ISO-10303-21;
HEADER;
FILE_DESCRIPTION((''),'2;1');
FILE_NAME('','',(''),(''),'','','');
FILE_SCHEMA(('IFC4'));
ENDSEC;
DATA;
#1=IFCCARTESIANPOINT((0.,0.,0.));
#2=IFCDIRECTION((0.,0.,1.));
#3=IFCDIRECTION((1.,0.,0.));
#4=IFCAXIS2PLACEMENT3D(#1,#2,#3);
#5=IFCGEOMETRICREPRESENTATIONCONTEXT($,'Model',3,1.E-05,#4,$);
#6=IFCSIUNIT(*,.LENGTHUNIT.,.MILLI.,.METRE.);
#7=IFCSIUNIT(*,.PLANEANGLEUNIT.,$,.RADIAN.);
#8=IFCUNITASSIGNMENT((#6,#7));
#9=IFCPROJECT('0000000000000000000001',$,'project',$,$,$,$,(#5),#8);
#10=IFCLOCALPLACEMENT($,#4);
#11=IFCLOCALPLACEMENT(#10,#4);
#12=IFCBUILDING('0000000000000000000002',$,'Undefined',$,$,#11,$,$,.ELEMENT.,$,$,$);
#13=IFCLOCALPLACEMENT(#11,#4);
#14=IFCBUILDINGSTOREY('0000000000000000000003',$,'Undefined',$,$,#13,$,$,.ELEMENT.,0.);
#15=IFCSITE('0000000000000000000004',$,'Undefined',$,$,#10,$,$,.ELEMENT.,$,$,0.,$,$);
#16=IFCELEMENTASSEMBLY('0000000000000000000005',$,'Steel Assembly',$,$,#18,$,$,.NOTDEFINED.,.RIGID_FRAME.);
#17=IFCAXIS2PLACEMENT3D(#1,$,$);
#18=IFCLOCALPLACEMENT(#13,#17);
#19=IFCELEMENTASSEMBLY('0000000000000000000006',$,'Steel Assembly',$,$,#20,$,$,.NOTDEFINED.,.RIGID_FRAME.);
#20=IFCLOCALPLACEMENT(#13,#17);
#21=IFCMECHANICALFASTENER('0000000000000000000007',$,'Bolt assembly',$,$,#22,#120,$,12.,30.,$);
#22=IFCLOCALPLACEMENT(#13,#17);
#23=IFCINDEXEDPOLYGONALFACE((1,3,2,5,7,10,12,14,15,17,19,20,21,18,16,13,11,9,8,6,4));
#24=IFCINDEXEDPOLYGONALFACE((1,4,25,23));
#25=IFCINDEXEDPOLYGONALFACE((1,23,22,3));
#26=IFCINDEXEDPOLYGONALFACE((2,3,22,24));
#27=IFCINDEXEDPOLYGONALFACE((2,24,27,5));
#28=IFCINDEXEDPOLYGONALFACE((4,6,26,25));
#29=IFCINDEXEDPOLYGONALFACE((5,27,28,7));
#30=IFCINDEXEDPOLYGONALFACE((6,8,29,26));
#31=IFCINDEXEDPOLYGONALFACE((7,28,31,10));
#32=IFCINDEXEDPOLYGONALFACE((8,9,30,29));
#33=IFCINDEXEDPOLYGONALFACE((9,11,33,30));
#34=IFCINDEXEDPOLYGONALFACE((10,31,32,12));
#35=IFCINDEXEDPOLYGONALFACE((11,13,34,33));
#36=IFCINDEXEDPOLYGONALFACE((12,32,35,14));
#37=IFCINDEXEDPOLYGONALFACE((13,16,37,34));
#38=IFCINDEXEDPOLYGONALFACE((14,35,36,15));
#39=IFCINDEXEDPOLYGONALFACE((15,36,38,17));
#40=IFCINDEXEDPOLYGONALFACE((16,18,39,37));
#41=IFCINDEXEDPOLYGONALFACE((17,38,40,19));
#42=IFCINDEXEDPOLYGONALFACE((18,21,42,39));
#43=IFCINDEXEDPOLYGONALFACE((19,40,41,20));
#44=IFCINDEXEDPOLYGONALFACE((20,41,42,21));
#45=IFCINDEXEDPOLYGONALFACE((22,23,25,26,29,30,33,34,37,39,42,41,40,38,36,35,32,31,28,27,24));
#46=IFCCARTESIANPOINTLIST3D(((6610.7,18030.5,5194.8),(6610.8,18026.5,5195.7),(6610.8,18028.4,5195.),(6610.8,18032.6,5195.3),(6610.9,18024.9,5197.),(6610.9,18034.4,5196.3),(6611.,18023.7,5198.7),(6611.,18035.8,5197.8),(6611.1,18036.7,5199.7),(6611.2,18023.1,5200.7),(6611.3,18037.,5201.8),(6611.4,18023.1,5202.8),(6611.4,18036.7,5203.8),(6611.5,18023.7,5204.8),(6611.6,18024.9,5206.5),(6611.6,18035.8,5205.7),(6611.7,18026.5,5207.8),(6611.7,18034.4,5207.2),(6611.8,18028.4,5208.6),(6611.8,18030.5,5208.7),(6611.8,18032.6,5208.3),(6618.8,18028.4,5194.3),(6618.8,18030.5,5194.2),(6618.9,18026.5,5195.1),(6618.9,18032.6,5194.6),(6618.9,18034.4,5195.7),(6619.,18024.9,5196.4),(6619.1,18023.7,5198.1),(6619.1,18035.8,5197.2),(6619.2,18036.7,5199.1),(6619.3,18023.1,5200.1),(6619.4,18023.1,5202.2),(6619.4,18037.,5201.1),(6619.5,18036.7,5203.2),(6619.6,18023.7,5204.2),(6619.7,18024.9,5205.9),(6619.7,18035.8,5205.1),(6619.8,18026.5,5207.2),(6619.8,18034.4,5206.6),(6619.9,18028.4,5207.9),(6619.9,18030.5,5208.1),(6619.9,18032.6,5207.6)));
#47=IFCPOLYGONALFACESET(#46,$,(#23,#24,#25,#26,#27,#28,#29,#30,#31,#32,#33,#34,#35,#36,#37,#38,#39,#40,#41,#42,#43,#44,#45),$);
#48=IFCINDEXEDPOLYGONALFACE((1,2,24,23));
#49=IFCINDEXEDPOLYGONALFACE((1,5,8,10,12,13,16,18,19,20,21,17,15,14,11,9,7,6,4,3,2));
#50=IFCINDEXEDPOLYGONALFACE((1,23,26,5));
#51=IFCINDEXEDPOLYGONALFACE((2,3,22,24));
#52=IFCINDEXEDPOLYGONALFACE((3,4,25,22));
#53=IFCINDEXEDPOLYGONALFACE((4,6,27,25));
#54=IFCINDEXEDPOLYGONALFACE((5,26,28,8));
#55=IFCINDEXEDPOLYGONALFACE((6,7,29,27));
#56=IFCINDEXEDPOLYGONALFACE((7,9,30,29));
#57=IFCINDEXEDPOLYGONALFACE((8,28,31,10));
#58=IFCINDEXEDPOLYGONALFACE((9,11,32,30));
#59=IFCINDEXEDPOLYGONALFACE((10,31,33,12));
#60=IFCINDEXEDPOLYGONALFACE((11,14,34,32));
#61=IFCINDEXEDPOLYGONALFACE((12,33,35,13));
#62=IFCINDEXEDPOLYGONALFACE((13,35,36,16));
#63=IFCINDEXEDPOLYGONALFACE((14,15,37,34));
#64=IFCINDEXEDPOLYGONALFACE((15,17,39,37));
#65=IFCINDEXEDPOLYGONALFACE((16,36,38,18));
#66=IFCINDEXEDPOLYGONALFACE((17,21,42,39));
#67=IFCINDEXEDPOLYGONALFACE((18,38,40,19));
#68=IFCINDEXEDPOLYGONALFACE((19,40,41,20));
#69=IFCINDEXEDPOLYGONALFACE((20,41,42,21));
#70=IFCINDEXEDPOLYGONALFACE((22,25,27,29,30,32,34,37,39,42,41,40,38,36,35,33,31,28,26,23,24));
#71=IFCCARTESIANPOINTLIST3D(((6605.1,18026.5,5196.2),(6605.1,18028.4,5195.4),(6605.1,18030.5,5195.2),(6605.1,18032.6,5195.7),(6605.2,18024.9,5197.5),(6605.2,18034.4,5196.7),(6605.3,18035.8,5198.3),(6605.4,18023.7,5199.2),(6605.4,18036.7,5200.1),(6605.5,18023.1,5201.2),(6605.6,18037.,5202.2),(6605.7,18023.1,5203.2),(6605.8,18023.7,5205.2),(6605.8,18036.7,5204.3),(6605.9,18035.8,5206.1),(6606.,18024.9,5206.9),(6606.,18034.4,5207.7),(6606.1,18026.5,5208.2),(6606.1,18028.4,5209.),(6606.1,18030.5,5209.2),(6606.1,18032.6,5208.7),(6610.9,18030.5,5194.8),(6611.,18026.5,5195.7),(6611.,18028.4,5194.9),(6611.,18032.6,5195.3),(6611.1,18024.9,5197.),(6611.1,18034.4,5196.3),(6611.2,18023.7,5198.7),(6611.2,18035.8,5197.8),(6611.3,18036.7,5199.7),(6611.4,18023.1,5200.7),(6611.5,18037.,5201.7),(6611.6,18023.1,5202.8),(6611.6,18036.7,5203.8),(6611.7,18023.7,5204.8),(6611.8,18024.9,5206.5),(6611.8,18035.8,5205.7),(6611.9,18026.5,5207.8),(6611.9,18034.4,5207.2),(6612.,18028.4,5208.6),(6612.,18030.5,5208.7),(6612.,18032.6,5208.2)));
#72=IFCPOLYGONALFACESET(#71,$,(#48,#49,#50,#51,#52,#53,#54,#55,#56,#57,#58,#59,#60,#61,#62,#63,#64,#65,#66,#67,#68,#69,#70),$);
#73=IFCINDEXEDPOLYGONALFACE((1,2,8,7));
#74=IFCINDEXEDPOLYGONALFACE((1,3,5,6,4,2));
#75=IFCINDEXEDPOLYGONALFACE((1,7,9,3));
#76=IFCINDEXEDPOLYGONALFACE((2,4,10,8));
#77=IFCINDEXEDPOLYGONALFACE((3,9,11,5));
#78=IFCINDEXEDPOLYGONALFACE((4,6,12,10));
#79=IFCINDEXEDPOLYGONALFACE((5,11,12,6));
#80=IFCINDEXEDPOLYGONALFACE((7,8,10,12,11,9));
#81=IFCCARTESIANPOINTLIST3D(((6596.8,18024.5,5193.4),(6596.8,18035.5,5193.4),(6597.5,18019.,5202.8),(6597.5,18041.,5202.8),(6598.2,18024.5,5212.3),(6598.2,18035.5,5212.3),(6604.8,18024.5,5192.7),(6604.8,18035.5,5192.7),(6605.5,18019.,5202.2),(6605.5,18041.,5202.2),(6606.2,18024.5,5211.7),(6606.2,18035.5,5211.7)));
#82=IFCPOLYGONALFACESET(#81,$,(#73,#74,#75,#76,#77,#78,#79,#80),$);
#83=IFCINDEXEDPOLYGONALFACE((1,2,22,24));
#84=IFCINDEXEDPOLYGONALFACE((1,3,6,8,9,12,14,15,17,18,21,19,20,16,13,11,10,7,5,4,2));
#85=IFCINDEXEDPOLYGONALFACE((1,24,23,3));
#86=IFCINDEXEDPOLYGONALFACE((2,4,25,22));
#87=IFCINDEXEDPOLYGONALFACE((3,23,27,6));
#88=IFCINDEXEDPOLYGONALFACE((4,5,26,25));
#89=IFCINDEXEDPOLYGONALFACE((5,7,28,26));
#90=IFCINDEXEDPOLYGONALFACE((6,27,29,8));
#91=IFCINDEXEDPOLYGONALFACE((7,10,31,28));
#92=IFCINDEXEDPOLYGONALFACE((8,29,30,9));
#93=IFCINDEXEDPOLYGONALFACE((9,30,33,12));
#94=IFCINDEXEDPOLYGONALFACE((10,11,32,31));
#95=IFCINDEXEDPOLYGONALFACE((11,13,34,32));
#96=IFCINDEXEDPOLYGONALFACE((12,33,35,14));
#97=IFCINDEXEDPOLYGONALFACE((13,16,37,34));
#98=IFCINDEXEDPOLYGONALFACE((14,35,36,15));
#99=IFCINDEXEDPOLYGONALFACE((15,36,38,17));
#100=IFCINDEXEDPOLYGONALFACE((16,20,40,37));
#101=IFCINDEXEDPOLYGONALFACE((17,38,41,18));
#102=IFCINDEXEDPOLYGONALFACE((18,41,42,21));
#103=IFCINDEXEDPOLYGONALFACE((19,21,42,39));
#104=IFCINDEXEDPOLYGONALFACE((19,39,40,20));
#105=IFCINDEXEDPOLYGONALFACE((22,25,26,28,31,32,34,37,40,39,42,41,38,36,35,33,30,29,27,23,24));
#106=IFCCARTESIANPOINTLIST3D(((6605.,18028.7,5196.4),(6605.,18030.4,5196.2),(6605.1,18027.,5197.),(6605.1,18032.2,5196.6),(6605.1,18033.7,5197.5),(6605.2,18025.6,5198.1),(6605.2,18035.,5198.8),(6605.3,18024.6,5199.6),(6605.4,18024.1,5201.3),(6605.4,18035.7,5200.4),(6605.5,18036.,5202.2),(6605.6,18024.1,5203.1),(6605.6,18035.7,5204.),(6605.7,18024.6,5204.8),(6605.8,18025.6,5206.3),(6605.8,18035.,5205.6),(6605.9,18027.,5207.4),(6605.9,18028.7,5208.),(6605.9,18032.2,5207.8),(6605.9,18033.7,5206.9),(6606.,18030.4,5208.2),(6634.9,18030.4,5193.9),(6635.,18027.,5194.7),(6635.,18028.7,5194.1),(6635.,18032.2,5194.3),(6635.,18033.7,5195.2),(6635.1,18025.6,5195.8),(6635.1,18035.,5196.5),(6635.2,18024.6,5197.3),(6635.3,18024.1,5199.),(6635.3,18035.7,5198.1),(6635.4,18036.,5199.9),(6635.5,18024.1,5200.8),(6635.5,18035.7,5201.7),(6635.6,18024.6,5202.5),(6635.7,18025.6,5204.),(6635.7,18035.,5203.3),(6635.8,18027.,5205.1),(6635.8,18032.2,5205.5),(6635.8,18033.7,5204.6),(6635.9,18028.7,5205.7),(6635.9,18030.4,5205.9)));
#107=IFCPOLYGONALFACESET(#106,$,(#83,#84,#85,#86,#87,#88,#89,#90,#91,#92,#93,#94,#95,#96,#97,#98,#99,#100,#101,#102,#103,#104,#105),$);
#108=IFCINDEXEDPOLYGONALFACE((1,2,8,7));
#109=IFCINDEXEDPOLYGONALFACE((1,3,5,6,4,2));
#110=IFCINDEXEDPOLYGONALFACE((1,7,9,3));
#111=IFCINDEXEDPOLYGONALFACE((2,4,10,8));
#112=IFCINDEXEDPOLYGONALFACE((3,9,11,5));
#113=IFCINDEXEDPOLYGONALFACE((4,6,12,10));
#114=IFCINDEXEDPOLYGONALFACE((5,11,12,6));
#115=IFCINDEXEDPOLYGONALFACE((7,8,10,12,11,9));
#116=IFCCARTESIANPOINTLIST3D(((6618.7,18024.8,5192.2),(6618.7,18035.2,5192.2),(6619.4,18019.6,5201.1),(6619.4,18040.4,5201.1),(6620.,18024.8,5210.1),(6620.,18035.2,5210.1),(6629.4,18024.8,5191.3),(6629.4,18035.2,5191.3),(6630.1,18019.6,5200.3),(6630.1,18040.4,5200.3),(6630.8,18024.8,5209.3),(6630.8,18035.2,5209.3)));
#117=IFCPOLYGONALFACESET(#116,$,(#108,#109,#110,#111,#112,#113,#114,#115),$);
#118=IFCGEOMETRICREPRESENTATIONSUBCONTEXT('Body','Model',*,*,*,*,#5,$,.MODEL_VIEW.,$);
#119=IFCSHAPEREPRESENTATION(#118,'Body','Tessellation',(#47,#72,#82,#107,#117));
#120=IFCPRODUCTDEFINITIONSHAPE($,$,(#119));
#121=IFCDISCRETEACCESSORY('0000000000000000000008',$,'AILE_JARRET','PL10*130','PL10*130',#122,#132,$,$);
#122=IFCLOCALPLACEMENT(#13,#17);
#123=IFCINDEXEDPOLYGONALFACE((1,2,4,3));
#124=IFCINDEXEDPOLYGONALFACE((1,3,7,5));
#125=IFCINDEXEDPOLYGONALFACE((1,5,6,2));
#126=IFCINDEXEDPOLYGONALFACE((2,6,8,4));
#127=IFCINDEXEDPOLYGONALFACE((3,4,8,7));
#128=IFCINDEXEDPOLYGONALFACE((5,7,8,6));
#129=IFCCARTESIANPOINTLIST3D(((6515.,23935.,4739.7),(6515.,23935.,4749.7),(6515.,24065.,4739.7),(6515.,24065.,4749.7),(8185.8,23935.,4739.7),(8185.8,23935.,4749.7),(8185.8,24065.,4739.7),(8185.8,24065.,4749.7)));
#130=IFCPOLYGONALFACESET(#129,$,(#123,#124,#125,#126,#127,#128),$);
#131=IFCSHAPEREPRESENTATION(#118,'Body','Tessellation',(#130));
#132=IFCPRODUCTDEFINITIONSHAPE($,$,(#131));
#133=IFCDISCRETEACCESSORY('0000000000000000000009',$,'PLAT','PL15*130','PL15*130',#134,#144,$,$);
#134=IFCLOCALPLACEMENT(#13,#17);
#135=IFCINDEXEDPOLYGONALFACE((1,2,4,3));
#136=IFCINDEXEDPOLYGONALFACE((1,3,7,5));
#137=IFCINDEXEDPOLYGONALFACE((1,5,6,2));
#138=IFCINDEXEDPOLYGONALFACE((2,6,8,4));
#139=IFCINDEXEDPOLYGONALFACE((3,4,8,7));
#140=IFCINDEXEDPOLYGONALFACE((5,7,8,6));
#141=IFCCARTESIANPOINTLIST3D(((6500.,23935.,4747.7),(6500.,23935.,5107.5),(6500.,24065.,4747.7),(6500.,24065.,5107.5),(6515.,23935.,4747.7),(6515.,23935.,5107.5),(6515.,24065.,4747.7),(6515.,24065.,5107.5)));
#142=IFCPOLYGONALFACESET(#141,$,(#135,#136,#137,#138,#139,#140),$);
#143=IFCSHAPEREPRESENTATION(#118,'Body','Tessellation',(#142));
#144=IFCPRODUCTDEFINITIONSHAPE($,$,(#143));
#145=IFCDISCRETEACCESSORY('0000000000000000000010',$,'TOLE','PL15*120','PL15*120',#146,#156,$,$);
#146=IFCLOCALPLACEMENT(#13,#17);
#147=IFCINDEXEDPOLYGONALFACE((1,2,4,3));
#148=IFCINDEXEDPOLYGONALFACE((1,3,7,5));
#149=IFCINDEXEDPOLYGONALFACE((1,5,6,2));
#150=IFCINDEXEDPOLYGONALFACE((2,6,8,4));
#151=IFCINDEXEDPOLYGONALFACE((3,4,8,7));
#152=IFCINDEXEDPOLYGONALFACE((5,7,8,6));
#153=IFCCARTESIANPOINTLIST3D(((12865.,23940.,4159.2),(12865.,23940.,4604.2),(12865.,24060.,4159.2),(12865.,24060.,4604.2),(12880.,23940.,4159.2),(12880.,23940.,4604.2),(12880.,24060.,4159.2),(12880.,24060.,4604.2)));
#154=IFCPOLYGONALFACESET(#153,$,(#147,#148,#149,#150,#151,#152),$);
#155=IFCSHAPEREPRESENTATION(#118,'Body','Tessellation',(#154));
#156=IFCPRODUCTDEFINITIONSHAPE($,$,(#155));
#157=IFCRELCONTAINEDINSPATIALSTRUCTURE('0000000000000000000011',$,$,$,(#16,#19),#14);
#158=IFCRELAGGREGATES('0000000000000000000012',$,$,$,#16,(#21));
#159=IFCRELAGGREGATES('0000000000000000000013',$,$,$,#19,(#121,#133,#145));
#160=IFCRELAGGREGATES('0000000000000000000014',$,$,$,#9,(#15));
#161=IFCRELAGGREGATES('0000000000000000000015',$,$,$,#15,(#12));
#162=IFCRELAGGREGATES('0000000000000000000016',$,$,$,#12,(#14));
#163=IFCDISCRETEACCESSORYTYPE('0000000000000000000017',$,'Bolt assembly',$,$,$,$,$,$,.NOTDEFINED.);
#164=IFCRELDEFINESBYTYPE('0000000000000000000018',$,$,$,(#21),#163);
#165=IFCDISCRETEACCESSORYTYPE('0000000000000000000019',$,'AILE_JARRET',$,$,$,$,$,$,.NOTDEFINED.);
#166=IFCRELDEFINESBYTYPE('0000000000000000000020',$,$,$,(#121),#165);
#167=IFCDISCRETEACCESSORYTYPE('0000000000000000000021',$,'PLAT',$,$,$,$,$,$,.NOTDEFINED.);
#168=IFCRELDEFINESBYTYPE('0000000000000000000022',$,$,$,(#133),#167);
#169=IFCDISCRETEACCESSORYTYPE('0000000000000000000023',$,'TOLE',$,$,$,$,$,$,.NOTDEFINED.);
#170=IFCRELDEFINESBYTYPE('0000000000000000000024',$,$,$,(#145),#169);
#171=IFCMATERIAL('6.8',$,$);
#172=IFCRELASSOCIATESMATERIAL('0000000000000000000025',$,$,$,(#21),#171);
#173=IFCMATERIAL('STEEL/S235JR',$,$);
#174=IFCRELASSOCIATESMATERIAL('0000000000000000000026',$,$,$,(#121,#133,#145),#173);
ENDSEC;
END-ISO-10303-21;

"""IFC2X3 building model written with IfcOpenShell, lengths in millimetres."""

from ifc_helpers import new_model, si_unit, frame, origin_with_axes, origin_2d_with_axis, place, context, subcontext, project, spatial, polyline, circle, outline, extrude, source, transform, mapped, material, type_object, element, aggregate, save


model = new_model("IFC2X3")

# Units and contexts
model_context = context("Model", 3, precision=1e-05, world=origin_with_axes())
body_context = subcontext(model_context, "Body", "Model", "MODEL_VIEW")
ifc_project = project(units=[si_unit("LENGTHUNIT", "METRE", prefix="MILLI"), si_unit("PLANEANGLEUNIT", "RADIAN")], contexts=[model_context])

# Site, building, storey
site_placement = place(None, origin_with_axes())
site = spatial("IfcSite", under=ifc_project, at=site_placement, Name="Undefined", CompositionType="ELEMENT", RefElevation=0.0)
building_placement = place(site_placement, origin_with_axes())
building = spatial("IfcBuilding", under=site, at=building_placement, Name="Undefined", CompositionType="ELEMENT")
storey_placement = place(building_placement, origin_with_axes())
storey = spatial("IfcBuildingStorey", under=building, at=storey_placement, Name="Undefined", CompositionType="ELEMENT", Elevation=0.0)

# Element assembly
ifc_material_1 = material(Name="STEEL/S235JR")
assembly_1_placement = place(storey_placement, origin_with_axes())
assembly_1 = element("IfcElementAssembly", 1, at=assembly_1_placement, inside=storey, Name="Steel Assembly", AssemblyPlace="NOTDEFINED", PredefinedType="RIGID_FRAME")

# Shared definitions
ifc_material_2 = material(Name="6.8")
discrete_accessory_type_1 = type_object("IfcDiscreteAccessoryType", Name="Bolt assembly")

# Element assembly
assembly_2_placement = place(storey_placement, origin_with_axes())
assembly_2 = element("IfcElementAssembly", 2, at=assembly_2_placement, inside=storey, Name="Steel Assembly", AssemblyPlace="NOTDEFINED", PredefinedType="RIGID_FRAME")

# Mechanical fastener
shared_shape_1 = source(origin_with_axes(), body_context, "Body", "SweptSolid", [
    extrude(circle(Radius=7.0, at=origin_2d_with_axis()), frame((0.0, 2.9, 0.0), z_axis=(0.0, 1.0, 0.0), x_axis=(1.0, 0.0, 0.0)), (0.0, 0.0, 1.0), 8.1),
    extrude(circle(Radius=7.0, at=origin_2d_with_axis()), frame((0.0, -2.9, 0.0), z_axis=(0.0, 1.0, 0.0), x_axis=(1.0, 0.0, 0.0)), (0.0, 0.0, 1.0), 5.9),
    extrude(outline(polyline([(11.0, 0.0), (5.5, 9.5), (-5.5, 9.5), (-11.0, 0.0), (-5.5, -9.5), (5.5, -9.5), (11.0, 0.0)])), frame((0.0, -11.0, 0.0), z_axis=(0.0, 1.0, 0.0), x_axis=(1.0, 0.0, 0.0)), (0.0, 0.0, 1.0), 8.0),
    extrude(circle(Radius=6.0, at=origin_2d_with_axis()), frame((0.0, -3.0, 0.0), z_axis=(0.0, 1.0, 0.0), x_axis=(1.0, 0.0, 0.0)), (0.0, 0.0, 1.0), 30.0),
    extrude(outline(polyline([(10.4, 0.0), (5.2, 9.0), (-5.2, 9.0), (-10.4, 0.0), (-5.2, -9.0), (5.2, -9.0), (10.4, 0.0)])), frame((0.0, 11.0, 0.0), z_axis=(0.0, 1.0, 0.0), x_axis=(1.0, 0.0, 0.0)), (0.0, 0.0, 1.0), 10.8),
])
mechanical_fastener_1_placement = place(assembly_1_placement, frame((6608.4, 18000.0, 5202.0), z_axis=(-0.076696, 0.0, -0.997054), x_axis=(0.0, 1.0, 0.0)))
mechanical_fastener_1 = element("IfcMechanicalFastener", 3, at=mechanical_fastener_1_placement, type_object=discrete_accessory_type_1, material=ifc_material_2, Name="Bolt assembly", NominalDiameter=12.0, NominalLength=30.0, context=body_context, shape_type="MappedRepresentation", body=[
    mapped(shared_shape_1, transform((30.0, 0.0, 0.0))),
])
aggregate(assembly_1, [mechanical_fastener_1])

# Discrete accessories
discrete_accessory_type_2 = type_object("IfcDiscreteAccessoryType", Name="AILE_JARRET")
discrete_accessory_1_placement = place(assembly_2_placement, frame((6515.0, 24000.0, 4744.7), z_axis=(0.0, 0.0, -1.0), x_axis=(1.0, 0.0, 0.0)))
discrete_accessory_1 = element("IfcDiscreteAccessory", 4, at=discrete_accessory_1_placement, type_object=discrete_accessory_type_2, material=ifc_material_1, Name="AILE_JARRET", Description="PL10*130", ObjectType="PL10*130", context=body_context, shape_type="SweptSolid", body=[
    extrude(outline(polyline([(0.0, 65.0), (1670.8, 65.0), (1670.8, -65.0), (0.0, -65.0), (0.0, 65.0)])), frame((0.0, 0.0, -5.0), z_axis=(0.0, 0.0, 1.0), x_axis=(1.0, 0.0, 0.0)), (0.0, 0.0, 1.0), 10.0),
])
discrete_accessory_type_3 = type_object("IfcDiscreteAccessoryType", Name="PLAT")
discrete_accessory_2_placement = place(assembly_2_placement, frame((6507.5, 24000.0, 5107.5), z_axis=(-1.0, 0.0, 0.0), x_axis=(0.0, 0.0, -1.0)))
discrete_accessory_2 = element("IfcDiscreteAccessory", 5, at=discrete_accessory_2_placement, type_object=discrete_accessory_type_3, material=ifc_material_1, Name="PLAT", Description="PL15*130", ObjectType="PL15*130", context=body_context, shape_type="SweptSolid", body=[
    extrude(outline(polyline([(359.8, 65.0), (359.8, -65.0), (0.0, -65.0), (0.0, 65.0), (359.8, 65.0)])), frame((0.0, 0.0, -7.5), z_axis=(0.0, 0.0, 1.0), x_axis=(1.0, 0.0, 0.0)), (0.0, 0.0, 1.0), 15.0),
])

# Discrete accessory
discrete_accessory_type_4 = type_object("IfcDiscreteAccessoryType", Name="TOLE")
discrete_accessory_3_placement = place(assembly_2_placement, frame((12872.5, 24000.0, 4159.2), z_axis=(1.0, 0.0, 0.0), x_axis=(0.0, 0.0, 1.0)))
discrete_accessory_3 = element("IfcDiscreteAccessory", 6, at=discrete_accessory_3_placement, type_object=discrete_accessory_type_4, material=ifc_material_1, Name="TOLE", Description="PL15*120", ObjectType="PL15*120", context=body_context, shape_type="SweptSolid", body=[
    extrude(outline(polyline([(0.0, 60.0), (445.0, 60.0), (445.0, -60.0), (0.0, -60.0), (0.0, 60.0)])), frame((0.0, 0.0, -7.5), z_axis=(0.0, 0.0, 1.0), x_axis=(1.0, 0.0, 0.0)), (0.0, 0.0, 1.0), 15.0),
])
aggregate(assembly_2, [discrete_accessory_1, discrete_accessory_2, discrete_accessory_3])

save(model, "model.ifc")
